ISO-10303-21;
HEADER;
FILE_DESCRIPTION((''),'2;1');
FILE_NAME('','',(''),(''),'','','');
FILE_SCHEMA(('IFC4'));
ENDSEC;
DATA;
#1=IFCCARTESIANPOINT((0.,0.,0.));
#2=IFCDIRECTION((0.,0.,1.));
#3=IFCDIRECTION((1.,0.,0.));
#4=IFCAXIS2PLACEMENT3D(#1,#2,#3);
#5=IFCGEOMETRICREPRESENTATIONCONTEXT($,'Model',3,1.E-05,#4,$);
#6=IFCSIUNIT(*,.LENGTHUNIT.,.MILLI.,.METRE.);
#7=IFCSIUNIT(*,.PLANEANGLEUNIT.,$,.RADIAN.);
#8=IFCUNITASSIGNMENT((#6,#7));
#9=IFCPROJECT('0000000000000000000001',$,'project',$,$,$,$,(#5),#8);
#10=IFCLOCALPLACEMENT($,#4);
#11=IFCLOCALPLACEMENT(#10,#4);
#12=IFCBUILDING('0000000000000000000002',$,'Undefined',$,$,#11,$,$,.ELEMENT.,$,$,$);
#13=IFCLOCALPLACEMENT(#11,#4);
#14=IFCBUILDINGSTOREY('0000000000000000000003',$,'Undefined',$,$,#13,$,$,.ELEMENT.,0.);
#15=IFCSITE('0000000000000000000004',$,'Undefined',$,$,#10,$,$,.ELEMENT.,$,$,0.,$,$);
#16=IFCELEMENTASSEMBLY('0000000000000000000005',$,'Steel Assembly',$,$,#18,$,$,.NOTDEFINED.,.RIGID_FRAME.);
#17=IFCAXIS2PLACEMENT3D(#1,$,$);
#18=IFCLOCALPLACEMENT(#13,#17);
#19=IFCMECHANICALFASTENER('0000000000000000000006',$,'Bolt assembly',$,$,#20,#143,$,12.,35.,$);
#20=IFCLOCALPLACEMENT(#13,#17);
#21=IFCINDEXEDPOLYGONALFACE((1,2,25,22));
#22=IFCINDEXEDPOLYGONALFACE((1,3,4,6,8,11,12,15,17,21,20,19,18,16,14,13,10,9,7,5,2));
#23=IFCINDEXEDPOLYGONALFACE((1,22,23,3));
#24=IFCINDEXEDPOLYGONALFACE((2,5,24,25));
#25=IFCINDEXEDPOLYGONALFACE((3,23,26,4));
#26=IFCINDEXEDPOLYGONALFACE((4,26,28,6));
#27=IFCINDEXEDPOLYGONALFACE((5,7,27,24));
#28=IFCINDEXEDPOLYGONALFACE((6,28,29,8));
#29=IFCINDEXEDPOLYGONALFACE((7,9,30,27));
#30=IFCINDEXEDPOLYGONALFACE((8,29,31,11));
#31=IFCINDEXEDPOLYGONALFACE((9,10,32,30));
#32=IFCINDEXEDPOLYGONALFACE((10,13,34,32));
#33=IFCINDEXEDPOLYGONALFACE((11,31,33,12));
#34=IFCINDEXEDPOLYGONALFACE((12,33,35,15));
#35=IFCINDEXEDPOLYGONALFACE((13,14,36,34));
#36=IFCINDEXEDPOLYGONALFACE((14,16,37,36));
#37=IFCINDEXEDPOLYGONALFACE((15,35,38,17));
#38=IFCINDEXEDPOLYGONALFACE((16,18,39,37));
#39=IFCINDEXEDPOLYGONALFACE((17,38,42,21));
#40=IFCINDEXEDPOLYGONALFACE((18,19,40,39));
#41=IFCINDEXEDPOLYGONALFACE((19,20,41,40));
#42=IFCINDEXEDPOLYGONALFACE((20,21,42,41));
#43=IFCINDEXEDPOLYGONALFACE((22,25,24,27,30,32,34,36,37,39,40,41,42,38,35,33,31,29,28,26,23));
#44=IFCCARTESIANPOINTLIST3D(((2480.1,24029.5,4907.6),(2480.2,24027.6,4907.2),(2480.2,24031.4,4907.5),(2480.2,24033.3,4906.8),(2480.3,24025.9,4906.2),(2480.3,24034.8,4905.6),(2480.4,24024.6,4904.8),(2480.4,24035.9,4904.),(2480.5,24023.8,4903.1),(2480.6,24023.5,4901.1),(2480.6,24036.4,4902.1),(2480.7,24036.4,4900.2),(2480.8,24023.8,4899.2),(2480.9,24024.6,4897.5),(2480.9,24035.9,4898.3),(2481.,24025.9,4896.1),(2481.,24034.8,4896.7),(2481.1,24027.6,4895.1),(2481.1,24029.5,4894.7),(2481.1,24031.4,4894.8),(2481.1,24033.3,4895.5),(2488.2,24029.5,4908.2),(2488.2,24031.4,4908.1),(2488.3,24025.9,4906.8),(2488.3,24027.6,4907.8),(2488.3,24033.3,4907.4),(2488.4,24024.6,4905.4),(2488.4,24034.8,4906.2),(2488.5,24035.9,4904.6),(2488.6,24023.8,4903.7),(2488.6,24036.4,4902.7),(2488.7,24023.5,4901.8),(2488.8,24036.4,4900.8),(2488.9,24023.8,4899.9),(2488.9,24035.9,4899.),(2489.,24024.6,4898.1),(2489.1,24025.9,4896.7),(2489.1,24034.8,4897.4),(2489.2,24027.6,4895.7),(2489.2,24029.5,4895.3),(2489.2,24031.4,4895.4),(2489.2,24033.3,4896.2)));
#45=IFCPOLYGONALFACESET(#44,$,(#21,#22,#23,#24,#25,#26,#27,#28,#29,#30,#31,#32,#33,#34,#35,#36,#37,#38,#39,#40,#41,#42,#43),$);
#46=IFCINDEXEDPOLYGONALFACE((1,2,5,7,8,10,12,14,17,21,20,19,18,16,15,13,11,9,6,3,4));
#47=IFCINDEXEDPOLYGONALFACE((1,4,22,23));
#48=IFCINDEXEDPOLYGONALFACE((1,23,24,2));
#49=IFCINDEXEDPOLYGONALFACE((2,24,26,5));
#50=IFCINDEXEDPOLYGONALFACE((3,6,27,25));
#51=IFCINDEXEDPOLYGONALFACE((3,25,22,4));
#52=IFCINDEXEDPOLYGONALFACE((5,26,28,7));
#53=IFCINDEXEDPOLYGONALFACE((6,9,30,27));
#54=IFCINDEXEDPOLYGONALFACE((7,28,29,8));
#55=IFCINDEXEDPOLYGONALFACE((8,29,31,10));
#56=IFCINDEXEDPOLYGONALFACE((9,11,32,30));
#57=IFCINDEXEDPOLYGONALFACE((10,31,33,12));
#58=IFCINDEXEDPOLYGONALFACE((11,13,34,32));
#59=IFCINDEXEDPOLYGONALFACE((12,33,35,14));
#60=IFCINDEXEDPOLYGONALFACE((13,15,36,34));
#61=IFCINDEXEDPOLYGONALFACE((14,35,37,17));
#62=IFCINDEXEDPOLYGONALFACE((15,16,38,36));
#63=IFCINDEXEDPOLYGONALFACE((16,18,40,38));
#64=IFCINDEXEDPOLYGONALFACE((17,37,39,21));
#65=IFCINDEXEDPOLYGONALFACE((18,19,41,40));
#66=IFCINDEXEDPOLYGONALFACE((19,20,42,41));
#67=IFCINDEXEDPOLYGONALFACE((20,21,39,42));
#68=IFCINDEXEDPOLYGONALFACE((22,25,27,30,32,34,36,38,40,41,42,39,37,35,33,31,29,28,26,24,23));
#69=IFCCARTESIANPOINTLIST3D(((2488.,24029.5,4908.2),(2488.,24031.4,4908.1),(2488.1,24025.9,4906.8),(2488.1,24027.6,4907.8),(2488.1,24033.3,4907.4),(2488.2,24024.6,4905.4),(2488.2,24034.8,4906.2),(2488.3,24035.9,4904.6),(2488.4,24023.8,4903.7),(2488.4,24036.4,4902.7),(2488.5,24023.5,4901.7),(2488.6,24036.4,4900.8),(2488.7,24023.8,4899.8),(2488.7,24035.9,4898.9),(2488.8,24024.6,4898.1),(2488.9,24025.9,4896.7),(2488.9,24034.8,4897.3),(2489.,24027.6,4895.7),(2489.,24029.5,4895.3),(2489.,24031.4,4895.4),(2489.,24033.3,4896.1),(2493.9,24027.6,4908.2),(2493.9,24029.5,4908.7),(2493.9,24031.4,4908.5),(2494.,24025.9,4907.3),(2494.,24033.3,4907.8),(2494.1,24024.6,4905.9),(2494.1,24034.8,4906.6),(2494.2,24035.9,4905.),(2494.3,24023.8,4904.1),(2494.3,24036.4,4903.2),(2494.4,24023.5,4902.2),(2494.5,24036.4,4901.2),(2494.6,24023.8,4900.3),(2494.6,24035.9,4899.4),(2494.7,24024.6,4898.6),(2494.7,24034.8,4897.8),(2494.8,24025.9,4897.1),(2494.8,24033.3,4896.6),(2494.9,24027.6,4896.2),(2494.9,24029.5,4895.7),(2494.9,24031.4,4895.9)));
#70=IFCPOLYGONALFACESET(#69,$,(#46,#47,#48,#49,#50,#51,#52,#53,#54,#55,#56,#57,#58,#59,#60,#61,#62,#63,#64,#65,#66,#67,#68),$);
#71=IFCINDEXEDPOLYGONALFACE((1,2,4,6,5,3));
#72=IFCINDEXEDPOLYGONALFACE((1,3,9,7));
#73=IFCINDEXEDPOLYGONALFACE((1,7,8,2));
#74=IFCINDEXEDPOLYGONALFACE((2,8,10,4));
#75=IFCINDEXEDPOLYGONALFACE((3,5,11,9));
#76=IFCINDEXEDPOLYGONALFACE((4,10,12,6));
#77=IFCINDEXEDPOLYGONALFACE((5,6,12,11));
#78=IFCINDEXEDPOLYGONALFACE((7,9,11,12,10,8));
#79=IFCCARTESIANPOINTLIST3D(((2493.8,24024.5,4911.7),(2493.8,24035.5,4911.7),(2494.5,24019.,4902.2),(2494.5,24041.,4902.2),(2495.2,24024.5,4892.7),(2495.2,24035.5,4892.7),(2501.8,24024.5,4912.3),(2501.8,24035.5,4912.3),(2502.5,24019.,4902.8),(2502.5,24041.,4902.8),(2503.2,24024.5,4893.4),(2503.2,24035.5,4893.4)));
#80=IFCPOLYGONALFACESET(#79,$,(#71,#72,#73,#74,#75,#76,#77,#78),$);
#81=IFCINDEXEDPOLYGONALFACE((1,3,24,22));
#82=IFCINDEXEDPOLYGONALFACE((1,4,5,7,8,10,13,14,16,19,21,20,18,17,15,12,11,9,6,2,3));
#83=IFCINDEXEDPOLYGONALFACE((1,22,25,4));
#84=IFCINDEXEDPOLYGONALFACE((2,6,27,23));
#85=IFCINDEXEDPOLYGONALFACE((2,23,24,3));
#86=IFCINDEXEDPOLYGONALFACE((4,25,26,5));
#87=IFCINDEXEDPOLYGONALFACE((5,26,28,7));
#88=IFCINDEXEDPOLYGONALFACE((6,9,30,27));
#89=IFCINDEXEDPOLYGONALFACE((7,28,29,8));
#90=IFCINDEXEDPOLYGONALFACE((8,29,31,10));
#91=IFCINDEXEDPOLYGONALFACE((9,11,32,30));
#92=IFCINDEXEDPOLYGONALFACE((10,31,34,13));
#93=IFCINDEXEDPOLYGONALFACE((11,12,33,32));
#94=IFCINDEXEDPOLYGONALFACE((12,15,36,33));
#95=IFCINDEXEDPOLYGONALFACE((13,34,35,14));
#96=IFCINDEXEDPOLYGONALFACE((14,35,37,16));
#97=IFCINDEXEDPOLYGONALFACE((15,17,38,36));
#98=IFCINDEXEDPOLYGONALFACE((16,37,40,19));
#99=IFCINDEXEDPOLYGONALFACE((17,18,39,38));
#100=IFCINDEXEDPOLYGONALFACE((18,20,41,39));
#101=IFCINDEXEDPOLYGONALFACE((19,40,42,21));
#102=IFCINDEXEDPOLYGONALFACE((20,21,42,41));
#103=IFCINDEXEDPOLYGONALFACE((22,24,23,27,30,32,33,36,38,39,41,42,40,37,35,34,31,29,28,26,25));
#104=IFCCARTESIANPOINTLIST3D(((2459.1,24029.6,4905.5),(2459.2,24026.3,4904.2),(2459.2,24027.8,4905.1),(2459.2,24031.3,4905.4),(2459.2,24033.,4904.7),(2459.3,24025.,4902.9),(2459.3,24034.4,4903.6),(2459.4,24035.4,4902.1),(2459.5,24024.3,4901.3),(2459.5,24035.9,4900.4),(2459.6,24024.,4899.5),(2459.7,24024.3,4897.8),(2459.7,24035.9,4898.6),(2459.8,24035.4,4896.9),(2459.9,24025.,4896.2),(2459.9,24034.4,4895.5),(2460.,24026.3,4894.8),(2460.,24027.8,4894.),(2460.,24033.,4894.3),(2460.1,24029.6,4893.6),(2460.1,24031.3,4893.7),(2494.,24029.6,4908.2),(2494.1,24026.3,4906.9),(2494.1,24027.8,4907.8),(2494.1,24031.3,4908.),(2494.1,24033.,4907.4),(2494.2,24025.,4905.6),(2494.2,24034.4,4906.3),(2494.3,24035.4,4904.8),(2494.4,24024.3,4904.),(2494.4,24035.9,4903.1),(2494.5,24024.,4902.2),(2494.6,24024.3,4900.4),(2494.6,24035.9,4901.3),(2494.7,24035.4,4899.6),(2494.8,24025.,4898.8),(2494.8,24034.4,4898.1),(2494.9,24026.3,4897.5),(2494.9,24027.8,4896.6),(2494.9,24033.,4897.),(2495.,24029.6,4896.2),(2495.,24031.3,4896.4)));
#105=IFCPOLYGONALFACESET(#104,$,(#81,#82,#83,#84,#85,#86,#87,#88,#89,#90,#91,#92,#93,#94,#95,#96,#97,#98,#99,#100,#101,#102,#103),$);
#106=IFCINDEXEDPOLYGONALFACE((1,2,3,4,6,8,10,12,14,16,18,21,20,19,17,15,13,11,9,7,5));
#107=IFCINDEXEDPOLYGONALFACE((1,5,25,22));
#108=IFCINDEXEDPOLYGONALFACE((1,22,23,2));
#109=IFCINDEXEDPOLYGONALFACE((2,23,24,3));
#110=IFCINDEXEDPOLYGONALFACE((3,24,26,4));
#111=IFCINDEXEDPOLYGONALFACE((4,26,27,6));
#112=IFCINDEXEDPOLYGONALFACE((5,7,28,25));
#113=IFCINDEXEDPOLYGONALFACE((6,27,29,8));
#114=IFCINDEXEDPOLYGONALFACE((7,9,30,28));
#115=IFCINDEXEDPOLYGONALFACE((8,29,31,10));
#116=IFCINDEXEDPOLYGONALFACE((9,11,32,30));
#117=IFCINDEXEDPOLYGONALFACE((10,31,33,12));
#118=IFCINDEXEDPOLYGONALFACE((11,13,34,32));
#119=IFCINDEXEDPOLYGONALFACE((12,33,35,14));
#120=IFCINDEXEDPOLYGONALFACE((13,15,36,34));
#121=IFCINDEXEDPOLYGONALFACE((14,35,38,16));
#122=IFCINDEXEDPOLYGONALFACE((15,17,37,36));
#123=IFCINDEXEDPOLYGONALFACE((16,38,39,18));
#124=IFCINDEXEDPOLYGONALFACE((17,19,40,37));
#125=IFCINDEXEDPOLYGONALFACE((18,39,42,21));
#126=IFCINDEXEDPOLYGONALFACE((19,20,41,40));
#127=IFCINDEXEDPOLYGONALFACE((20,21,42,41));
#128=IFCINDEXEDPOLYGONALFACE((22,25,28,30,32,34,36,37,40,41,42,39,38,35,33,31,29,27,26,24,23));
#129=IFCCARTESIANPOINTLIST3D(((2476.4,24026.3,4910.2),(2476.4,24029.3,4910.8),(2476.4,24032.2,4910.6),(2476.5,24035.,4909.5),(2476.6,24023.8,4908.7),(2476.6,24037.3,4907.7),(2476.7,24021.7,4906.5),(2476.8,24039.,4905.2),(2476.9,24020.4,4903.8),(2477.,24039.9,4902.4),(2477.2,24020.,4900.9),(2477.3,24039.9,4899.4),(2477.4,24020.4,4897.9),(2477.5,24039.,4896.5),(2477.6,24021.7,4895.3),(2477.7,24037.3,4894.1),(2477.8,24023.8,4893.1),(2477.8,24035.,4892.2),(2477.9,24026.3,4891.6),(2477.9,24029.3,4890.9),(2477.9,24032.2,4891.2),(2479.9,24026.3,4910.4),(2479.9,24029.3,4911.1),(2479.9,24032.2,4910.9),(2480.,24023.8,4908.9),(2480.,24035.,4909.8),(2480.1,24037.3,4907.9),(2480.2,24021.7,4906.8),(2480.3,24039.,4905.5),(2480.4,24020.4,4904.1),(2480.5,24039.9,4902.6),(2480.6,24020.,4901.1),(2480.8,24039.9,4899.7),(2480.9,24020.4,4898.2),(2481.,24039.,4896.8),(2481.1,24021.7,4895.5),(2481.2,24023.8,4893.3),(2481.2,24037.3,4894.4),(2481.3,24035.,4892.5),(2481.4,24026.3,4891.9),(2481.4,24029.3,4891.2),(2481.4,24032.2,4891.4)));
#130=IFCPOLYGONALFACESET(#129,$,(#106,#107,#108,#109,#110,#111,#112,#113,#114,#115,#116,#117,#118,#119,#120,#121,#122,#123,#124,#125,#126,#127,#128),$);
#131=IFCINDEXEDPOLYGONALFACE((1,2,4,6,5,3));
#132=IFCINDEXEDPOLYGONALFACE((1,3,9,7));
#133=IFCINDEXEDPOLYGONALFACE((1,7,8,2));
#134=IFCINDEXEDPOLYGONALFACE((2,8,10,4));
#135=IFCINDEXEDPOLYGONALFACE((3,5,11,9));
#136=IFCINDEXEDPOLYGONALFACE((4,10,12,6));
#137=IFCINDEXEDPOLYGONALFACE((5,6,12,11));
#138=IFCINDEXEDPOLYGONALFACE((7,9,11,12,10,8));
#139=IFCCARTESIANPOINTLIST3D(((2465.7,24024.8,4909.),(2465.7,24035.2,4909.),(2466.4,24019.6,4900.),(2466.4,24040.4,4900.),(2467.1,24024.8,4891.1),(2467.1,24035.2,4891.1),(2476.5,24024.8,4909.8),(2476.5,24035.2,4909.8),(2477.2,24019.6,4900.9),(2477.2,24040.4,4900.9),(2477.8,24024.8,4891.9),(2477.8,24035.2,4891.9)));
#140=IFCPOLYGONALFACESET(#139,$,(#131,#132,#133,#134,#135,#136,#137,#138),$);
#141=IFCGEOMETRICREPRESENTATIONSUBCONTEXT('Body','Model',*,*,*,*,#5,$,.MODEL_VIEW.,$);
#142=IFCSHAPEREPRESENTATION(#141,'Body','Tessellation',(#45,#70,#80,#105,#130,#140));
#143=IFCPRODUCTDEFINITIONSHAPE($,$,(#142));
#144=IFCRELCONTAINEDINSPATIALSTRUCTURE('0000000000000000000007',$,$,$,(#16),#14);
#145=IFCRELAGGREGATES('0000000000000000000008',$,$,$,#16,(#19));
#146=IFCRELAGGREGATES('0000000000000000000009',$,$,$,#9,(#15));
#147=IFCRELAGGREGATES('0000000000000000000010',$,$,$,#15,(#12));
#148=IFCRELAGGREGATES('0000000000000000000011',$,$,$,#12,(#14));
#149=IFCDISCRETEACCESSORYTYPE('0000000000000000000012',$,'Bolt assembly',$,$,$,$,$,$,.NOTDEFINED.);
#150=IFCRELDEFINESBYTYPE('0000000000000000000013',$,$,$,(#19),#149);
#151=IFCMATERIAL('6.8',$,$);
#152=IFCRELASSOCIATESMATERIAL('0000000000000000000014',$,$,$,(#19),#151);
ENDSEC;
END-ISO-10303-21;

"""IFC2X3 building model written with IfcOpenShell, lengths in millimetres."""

from ifc_helpers import new_model, si_unit, frame, origin_with_axes, origin_2d_with_axis, place, context, subcontext, project, spatial, polyline, circle, outline, extrude, source, transform, mapped, material, type_object, element, aggregate, save


model = new_model("IFC2X3")

# Units and contexts
model_context = context("Model", 3, precision=1e-05, world=origin_with_axes())
body_context = subcontext(model_context, "Body", "Model", "MODEL_VIEW")
ifc_project = project(units=[si_unit("LENGTHUNIT", "METRE", prefix="MILLI"), si_unit("PLANEANGLEUNIT", "RADIAN")], contexts=[model_context])

# Site, building, storey
site_placement = place(None, origin_with_axes())
site = spatial("IfcSite", under=ifc_project, at=site_placement, Name="Undefined", CompositionType="ELEMENT", RefElevation=0.0)
building_placement = place(site_placement, origin_with_axes())
building = spatial("IfcBuilding", under=site, at=building_placement, Name="Undefined", CompositionType="ELEMENT")
storey_placement = place(building_placement, origin_with_axes())
storey = spatial("IfcBuildingStorey", under=building, at=storey_placement, Name="Undefined", CompositionType="ELEMENT", Elevation=0.0)

# Element assembly
assembly_1_placement = place(storey_placement, origin_with_axes())
assembly_1 = element("IfcElementAssembly", 1, at=assembly_1_placement, inside=storey, Name="Steel Assembly", AssemblyPlace="NOTDEFINED", PredefinedType="RIGID_FRAME")

# Mechanical fastener
ifc_material_1 = material(Name="6.8")
discrete_accessory_type_1 = type_object("IfcDiscreteAccessoryType", Name="Bolt assembly")
shared_shape_1 = source(origin_with_axes(), body_context, "Body", "SweptSolid", [
    extrude(circle(Radius=6.5, at=origin_2d_with_axis()), frame((0.0, 2.9, 0.0), z_axis=(0.0, 1.0, 0.0), x_axis=(1.0, 0.0, 0.0)), (0.0, 0.0, 1.0), 8.1),
    extrude(circle(Radius=6.5, at=origin_2d_with_axis()), frame((0.0, -2.9, 0.0), z_axis=(0.0, 1.0, 0.0), x_axis=(1.0, 0.0, 0.0)), (0.0, 0.0, 1.0), 5.9),
    extrude(outline(polyline([(11.0, 0.0), (5.5, 9.5), (-5.5, 9.5), (-11.0, 0.0), (-5.5, -9.5), (5.5, -9.5), (11.0, 0.0)])), frame((0.0, -11.0, 0.0), z_axis=(0.0, 1.0, 0.0), x_axis=(1.0, 0.0, 0.0)), (0.0, 0.0, 1.0), 8.0),
    extrude(circle(Radius=6.0, at=origin_2d_with_axis()), frame((0.0, -3.0, 0.0), z_axis=(0.0, 1.0, 0.0), x_axis=(1.0, 0.0, 0.0)), (0.0, 0.0, 1.0), 35.0),
    extrude(circle(Radius=10.0, at=origin_2d_with_axis()), frame((0.0, 11.0, 0.0), z_axis=(0.0, 1.0, 0.0), x_axis=(1.0, 0.0, 0.0)), (0.0, 0.0, 1.0), 3.5),
    extrude(outline(polyline([(10.4, 0.0), (5.2, 9.0), (-5.2, 9.0), (-10.4, 0.0), (-5.2, -9.0), (5.2, -9.0), (10.4, 0.0)])), frame((0.0, 14.5, 0.0), z_axis=(0.0, 1.0, 0.0), x_axis=(1.0, 0.0, 0.0)), (0.0, 0.0, 1.0), 10.8),
])
mechanical_fastener_1_placement = place(assembly_1_placement, frame((2491.6, 24030.0, 4902.0), z_axis=(0.076696, 0.0, -0.997054), x_axis=(0.0, -1.0, 0.0)))
mechanical_fastener_1 = element("IfcMechanicalFastener", 2, at=mechanical_fastener_1_placement, type_object=discrete_accessory_type_1, material=ifc_material_1, Name="Bolt assembly", NominalDiameter=12.0, NominalLength=35.0, context=body_context, shape_type="MappedRepresentation", body=[
    mapped(shared_shape_1, transform((0.0, 0.0, 0.0))),
])
aggregate(assembly_1, [mechanical_fastener_1])

save(model, "model.ifc")
